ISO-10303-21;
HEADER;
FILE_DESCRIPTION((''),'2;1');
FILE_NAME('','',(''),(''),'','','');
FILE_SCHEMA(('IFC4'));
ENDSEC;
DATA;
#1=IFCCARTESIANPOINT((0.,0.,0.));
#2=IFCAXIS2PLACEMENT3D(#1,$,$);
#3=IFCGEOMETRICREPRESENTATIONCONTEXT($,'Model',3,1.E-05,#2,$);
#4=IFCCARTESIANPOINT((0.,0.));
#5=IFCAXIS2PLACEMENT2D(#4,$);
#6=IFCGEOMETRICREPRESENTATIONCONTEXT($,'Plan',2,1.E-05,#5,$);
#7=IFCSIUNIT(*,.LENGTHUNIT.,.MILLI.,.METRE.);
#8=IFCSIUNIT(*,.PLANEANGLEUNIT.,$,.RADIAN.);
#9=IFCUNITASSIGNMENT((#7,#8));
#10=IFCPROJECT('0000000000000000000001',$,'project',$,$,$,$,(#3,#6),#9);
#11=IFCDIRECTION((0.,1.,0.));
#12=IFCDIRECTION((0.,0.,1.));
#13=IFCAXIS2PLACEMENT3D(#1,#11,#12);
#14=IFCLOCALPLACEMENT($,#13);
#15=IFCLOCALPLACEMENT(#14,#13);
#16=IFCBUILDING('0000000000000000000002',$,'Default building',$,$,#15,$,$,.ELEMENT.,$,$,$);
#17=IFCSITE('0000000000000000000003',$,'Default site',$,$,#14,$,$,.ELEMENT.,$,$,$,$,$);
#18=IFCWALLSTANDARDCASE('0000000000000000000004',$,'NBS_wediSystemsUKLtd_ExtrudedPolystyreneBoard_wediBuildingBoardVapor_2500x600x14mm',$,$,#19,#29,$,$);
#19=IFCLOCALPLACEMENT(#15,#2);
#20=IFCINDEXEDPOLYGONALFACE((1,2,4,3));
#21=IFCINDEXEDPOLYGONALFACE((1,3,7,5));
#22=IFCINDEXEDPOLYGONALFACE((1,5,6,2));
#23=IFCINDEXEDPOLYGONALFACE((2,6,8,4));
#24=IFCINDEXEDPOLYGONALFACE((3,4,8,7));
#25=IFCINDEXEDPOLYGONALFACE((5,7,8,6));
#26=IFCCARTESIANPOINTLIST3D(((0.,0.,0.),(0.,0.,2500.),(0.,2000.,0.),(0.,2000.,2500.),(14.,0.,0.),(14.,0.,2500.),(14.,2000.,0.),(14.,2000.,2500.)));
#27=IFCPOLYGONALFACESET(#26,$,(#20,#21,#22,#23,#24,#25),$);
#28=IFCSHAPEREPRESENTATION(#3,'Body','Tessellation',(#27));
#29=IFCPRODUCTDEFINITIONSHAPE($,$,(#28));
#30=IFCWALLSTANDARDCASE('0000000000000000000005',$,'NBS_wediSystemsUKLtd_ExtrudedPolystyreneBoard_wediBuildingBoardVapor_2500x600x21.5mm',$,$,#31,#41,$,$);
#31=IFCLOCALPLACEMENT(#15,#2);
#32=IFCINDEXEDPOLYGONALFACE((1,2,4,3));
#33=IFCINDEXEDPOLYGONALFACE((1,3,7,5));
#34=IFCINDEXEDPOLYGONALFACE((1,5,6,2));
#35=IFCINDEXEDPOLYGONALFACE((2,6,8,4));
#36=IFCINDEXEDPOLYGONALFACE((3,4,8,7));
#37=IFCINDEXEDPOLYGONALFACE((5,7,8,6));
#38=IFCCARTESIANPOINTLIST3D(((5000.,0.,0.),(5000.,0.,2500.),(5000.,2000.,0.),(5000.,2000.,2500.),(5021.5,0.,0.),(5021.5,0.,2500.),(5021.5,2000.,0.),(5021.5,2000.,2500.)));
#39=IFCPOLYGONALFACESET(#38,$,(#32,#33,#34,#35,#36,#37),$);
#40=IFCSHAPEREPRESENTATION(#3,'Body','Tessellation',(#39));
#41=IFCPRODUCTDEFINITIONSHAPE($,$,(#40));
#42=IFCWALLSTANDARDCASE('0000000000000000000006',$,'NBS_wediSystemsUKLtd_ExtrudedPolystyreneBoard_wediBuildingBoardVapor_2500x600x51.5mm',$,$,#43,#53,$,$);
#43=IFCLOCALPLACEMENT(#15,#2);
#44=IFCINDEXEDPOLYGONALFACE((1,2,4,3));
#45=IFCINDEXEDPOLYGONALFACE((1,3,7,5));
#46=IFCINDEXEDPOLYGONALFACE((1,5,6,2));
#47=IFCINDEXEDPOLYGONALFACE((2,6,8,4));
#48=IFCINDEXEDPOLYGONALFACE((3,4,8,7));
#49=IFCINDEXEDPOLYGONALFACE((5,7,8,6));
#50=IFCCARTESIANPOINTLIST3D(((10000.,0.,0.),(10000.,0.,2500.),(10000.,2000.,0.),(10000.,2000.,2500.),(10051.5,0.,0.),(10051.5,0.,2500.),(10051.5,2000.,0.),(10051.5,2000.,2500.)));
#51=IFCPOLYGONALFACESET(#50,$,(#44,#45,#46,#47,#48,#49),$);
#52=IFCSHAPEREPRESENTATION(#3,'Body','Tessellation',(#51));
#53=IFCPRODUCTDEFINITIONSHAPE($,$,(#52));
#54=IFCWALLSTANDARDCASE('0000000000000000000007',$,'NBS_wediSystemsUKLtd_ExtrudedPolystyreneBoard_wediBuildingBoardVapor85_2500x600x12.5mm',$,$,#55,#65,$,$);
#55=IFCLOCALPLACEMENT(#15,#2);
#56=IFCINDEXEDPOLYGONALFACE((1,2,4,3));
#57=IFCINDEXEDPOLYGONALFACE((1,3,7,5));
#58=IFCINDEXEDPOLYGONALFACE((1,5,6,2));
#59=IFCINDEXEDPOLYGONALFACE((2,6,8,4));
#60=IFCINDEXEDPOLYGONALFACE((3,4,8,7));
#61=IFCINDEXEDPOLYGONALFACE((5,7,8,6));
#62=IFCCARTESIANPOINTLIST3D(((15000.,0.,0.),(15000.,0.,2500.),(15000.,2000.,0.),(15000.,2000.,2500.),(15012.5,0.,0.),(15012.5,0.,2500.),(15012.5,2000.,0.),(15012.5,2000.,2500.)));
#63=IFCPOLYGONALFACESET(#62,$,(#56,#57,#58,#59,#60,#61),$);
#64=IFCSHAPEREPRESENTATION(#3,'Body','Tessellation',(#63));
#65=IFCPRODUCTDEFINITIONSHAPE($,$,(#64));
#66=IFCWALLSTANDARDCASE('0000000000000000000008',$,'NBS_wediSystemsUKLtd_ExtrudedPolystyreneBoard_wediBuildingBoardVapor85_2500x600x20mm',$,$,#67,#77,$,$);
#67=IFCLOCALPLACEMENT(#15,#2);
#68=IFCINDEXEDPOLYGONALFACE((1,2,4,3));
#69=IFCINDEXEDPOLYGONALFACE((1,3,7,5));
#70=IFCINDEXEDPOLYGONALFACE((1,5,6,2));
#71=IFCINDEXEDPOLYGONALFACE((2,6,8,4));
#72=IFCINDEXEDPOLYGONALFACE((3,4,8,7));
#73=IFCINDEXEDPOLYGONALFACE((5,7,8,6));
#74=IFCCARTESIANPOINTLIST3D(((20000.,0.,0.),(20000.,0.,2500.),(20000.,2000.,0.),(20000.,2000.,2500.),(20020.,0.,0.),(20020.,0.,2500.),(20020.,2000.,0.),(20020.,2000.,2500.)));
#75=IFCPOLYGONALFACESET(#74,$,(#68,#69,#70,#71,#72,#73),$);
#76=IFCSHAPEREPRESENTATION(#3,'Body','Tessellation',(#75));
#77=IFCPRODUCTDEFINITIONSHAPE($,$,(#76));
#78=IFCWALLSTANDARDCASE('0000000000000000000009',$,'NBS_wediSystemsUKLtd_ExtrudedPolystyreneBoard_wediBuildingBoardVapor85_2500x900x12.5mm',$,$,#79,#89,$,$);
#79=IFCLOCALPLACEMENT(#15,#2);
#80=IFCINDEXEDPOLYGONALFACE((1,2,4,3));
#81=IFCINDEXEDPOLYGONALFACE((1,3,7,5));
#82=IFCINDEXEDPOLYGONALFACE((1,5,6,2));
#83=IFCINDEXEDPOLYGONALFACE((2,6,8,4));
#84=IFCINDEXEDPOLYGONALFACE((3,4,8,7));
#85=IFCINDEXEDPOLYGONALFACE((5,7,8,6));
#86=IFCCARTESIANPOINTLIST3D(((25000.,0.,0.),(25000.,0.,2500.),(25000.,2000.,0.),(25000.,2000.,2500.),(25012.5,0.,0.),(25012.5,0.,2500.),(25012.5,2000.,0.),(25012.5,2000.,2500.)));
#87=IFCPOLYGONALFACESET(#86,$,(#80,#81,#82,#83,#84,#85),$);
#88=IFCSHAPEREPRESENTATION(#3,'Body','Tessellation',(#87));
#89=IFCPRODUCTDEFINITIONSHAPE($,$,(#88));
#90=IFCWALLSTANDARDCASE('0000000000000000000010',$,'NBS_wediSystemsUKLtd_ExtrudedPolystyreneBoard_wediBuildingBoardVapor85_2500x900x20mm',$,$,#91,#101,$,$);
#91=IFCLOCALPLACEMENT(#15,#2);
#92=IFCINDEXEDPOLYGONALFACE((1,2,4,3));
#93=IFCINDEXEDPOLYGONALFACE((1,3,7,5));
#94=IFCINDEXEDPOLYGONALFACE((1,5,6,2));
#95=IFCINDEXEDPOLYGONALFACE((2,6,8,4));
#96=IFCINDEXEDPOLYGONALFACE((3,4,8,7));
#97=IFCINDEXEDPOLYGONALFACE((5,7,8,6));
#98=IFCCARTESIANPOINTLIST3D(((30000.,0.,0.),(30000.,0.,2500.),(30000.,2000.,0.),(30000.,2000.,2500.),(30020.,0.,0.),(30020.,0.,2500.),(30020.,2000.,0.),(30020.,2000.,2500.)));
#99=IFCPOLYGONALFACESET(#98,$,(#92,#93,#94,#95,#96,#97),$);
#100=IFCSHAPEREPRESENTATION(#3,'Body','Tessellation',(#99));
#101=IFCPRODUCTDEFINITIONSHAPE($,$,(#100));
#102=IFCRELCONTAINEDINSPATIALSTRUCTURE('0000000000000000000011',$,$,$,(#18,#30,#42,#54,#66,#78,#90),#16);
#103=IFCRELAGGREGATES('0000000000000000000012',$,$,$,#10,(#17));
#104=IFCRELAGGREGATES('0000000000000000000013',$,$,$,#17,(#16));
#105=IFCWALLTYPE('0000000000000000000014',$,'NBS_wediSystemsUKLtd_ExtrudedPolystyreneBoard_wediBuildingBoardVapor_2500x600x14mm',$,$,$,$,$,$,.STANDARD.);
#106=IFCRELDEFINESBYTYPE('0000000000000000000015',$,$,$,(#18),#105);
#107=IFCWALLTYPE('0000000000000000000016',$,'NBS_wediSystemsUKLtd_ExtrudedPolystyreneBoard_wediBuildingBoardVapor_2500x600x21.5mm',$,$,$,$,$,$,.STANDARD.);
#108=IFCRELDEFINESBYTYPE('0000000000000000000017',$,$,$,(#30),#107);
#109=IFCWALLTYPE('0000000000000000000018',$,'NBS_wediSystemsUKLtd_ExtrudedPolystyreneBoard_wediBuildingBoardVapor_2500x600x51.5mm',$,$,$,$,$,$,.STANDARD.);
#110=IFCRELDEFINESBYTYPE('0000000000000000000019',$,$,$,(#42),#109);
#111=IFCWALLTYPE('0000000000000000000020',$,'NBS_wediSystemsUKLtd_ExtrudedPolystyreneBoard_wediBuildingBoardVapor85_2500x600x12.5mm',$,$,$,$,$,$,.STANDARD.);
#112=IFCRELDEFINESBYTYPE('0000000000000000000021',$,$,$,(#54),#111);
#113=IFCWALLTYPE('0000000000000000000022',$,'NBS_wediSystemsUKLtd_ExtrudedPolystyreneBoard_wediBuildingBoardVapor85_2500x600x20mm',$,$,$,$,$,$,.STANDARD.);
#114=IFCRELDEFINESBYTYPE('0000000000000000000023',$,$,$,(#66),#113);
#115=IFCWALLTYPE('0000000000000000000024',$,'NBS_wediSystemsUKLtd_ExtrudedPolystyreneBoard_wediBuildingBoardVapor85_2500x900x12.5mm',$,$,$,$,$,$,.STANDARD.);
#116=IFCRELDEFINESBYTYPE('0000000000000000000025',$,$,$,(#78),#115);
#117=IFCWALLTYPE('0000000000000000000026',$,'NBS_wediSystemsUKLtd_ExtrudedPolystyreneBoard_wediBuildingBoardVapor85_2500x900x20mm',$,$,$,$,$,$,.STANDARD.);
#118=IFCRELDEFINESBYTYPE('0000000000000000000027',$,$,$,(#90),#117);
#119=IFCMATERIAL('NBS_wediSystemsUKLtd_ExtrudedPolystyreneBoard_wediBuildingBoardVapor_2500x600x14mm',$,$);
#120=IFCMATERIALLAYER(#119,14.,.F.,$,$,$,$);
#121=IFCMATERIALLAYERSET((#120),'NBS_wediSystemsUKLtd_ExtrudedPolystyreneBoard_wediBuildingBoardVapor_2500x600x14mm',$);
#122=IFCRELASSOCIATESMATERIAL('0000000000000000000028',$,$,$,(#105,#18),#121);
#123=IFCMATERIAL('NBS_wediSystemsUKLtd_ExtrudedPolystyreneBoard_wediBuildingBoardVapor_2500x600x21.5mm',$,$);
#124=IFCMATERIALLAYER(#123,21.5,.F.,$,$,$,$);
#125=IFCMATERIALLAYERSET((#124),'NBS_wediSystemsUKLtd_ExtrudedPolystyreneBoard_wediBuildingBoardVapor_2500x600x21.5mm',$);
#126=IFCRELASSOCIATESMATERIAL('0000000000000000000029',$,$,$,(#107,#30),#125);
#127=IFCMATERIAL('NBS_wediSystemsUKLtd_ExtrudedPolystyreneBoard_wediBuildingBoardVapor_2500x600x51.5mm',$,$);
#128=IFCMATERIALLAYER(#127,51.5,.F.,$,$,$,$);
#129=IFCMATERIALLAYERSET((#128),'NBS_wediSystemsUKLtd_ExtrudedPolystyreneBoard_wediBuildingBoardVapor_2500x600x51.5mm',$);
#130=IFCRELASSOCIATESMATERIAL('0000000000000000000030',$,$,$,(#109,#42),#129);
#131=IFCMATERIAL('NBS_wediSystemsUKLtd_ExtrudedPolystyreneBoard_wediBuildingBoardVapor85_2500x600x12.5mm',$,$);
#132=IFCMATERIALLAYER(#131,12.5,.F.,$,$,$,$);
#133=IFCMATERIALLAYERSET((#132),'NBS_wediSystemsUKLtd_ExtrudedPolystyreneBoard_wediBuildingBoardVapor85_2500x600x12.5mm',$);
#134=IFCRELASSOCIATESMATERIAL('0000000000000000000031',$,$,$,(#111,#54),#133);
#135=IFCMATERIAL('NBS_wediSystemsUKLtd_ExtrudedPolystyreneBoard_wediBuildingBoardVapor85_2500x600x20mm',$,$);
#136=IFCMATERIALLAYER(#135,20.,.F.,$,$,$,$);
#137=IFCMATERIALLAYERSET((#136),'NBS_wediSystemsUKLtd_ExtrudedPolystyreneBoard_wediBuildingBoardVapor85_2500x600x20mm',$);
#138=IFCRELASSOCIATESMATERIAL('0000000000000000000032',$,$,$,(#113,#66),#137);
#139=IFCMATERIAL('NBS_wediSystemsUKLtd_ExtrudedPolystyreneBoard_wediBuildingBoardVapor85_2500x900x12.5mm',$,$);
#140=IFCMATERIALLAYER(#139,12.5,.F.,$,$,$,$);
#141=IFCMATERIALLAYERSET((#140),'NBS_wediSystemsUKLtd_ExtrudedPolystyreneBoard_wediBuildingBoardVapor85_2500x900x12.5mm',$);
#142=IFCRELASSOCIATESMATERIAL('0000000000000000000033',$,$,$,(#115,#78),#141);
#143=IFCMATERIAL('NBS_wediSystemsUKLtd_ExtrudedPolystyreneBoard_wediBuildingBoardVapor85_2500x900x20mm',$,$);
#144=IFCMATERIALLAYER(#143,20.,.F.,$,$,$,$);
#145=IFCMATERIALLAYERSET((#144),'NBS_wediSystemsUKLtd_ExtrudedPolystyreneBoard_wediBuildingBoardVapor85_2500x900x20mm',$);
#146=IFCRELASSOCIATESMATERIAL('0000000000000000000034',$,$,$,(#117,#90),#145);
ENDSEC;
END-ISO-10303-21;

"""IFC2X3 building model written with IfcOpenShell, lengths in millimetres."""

from ifc_helpers import new_model, si_unit, frame, frame_2d, origin, origin_with_axes, origin_2d, place, context, project, spatial, rectangle, extrude, material, layer, layer_set, layer_usage, type_object, element, save


model = new_model("IFC2X3")

# Units and contexts
model_context = context("Model", 3, precision=1e-05, world=origin())
plan_context = context("Plan", 2, precision=1e-05, world=origin_2d())
ifc_project = project(units=[si_unit("LENGTHUNIT", "METRE", prefix="MILLI"), si_unit("PLANEANGLEUNIT", "RADIAN")], contexts=[model_context, plan_context])

# Site, building
site_placement = place(None, frame((0.0, 0.0, 0.0), z_axis=(0.0, 1.0, 0.0), x_axis=(0.0, 0.0, 1.0)))
site = spatial("IfcSite", under=ifc_project, at=site_placement, Name="Default site", CompositionType="ELEMENT")
building_placement = place(site_placement, frame((0.0, 0.0, 0.0), z_axis=(0.0, 1.0, 0.0), x_axis=(0.0, 0.0, 1.0)))
building = spatial("IfcBuilding", under=site, at=building_placement, Name="Default building", CompositionType="ELEMENT")

# Walls
ifc_material_1 = material(Name="NBS_wediSystemsUKLtd_ExtrudedPolystyreneBoard_wediBuildingBoardVapor_2500x600x14mm")
ifc_layer_1 = layer(ifc_material_1, 14.0, ventilated=False)
ifc_layer_set_1 = layer_set([ifc_layer_1], Name="NBS_wediSystemsUKLtd_ExtrudedPolystyreneBoard_wediBuildingBoardVapor_2500x600x14mm")
ifc_layer_usage_1 = layer_usage(ifc_layer_set_1, "AXIS2", "POSITIVE", 0.0)
wall_type_1 = type_object("IfcWallType", Name="NBS_wediSystemsUKLtd_ExtrudedPolystyreneBoard_wediBuildingBoardVapor_2500x600x14mm", PredefinedType="STANDARD", material=ifc_layer_set_1)
wall_1_placement = place(None, origin())
element("IfcWallStandardCase", 1, at=wall_1_placement, inside=building, type_object=wall_type_1, material=ifc_layer_usage_1, Name="NBS_wediSystemsUKLtd_ExtrudedPolystyreneBoard_wediBuildingBoardVapor_2500x600x14mm", context=model_context, shape_type="SweptSolid", body=[
    extrude(rectangle(XDim=2500.0, YDim=14.0, at=frame_2d((1250.0, 7.0))), origin_with_axes(), (0.0, 0.0, 1.0), 2000.0),
])
ifc_material_2 = material(Name="NBS_wediSystemsUKLtd_ExtrudedPolystyreneBoard_wediBuildingBoardVapor_2500x600x21.5mm")
ifc_layer_2 = layer(ifc_material_2, 21.5, ventilated=False)
ifc_layer_set_2 = layer_set([ifc_layer_2], Name="NBS_wediSystemsUKLtd_ExtrudedPolystyreneBoard_wediBuildingBoardVapor_2500x600x21.5mm")
ifc_layer_usage_2 = layer_usage(ifc_layer_set_2, "AXIS2", "POSITIVE", 0.0)
wall_type_2 = type_object("IfcWallType", Name="NBS_wediSystemsUKLtd_ExtrudedPolystyreneBoard_wediBuildingBoardVapor_2500x600x21.5mm", PredefinedType="STANDARD", material=ifc_layer_set_2)
wall_2_placement = place(None, frame((0.0, 5000.0, 0.0)))
element("IfcWallStandardCase", 2, at=wall_2_placement, inside=building, type_object=wall_type_2, material=ifc_layer_usage_2, Name="NBS_wediSystemsUKLtd_ExtrudedPolystyreneBoard_wediBuildingBoardVapor_2500x600x21.5mm", context=model_context, shape_type="SweptSolid", body=[
    extrude(rectangle(XDim=2500.0, YDim=21.5, at=frame_2d((1250.0, 10.8))), origin_with_axes(), (0.0, 0.0, 1.0), 2000.0),
])
ifc_material_3 = material(Name="NBS_wediSystemsUKLtd_ExtrudedPolystyreneBoard_wediBuildingBoardVapor_2500x600x51.5mm")
ifc_layer_3 = layer(ifc_material_3, 51.5, ventilated=False)
ifc_layer_set_3 = layer_set([ifc_layer_3], Name="NBS_wediSystemsUKLtd_ExtrudedPolystyreneBoard_wediBuildingBoardVapor_2500x600x51.5mm")
ifc_layer_usage_3 = layer_usage(ifc_layer_set_3, "AXIS2", "POSITIVE", 0.0)
wall_type_3 = type_object("IfcWallType", Name="NBS_wediSystemsUKLtd_ExtrudedPolystyreneBoard_wediBuildingBoardVapor_2500x600x51.5mm", PredefinedType="STANDARD", material=ifc_layer_set_3)
wall_3_placement = place(None, frame((0.0, 10000.0, 0.0)))
element("IfcWallStandardCase", 3, at=wall_3_placement, inside=building, type_object=wall_type_3, material=ifc_layer_usage_3, Name="NBS_wediSystemsUKLtd_ExtrudedPolystyreneBoard_wediBuildingBoardVapor_2500x600x51.5mm", context=model_context, shape_type="SweptSolid", body=[
    extrude(rectangle(XDim=2500.0, YDim=51.5, at=frame_2d((1250.0, 25.8))), origin_with_axes(), (0.0, 0.0, 1.0), 2000.0),
])
ifc_material_4 = material(Name="NBS_wediSystemsUKLtd_ExtrudedPolystyreneBoard_wediBuildingBoardVapor85_2500x600x12.5mm")
ifc_layer_4 = layer(ifc_material_4, 12.5, ventilated=False)
ifc_layer_set_4 = layer_set([ifc_layer_4], Name="NBS_wediSystemsUKLtd_ExtrudedPolystyreneBoard_wediBuildingBoardVapor85_2500x600x12.5mm")
ifc_layer_usage_4 = layer_usage(ifc_layer_set_4, "AXIS2", "POSITIVE", 0.0)
wall_type_4 = type_object("IfcWallType", Name="NBS_wediSystemsUKLtd_ExtrudedPolystyreneBoard_wediBuildingBoardVapor85_2500x600x12.5mm", PredefinedType="STANDARD", material=ifc_layer_set_4)
wall_4_placement = place(None, frame((0.0, 15000.0, 0.0)))
element("IfcWallStandardCase", 4, at=wall_4_placement, inside=building, type_object=wall_type_4, material=ifc_layer_usage_4, Name="NBS_wediSystemsUKLtd_ExtrudedPolystyreneBoard_wediBuildingBoardVapor85_2500x600x12.5mm", context=model_context, shape_type="SweptSolid", body=[
    extrude(rectangle(XDim=2500.0, YDim=12.5, at=frame_2d((1250.0, 6.2))), origin_with_axes(), (0.0, 0.0, 1.0), 2000.0),
])
ifc_material_5 = material(Name="NBS_wediSystemsUKLtd_ExtrudedPolystyreneBoard_wediBuildingBoardVapor85_2500x600x20mm")
ifc_layer_5 = layer(ifc_material_5, 20.0, ventilated=False)
ifc_layer_set_5 = layer_set([ifc_layer_5], Name="NBS_wediSystemsUKLtd_ExtrudedPolystyreneBoard_wediBuildingBoardVapor85_2500x600x20mm")
ifc_layer_usage_5 = layer_usage(ifc_layer_set_5, "AXIS2", "POSITIVE", 0.0)
wall_type_5 = type_object("IfcWallType", Name="NBS_wediSystemsUKLtd_ExtrudedPolystyreneBoard_wediBuildingBoardVapor85_2500x600x20mm", PredefinedType="STANDARD", material=ifc_layer_set_5)
wall_5_placement = place(None, frame((0.0, 20000.0, 0.0)))
element("IfcWallStandardCase", 5, at=wall_5_placement, inside=building, type_object=wall_type_5, material=ifc_layer_usage_5, Name="NBS_wediSystemsUKLtd_ExtrudedPolystyreneBoard_wediBuildingBoardVapor85_2500x600x20mm", context=model_context, shape_type="SweptSolid", body=[
    extrude(rectangle(XDim=2500.0, YDim=20.0, at=frame_2d((1250.0, 10.0))), origin_with_axes(), (0.0, 0.0, 1.0), 2000.0),
])
ifc_material_6 = material(Name="NBS_wediSystemsUKLtd_ExtrudedPolystyreneBoard_wediBuildingBoardVapor85_2500x900x12.5mm")
ifc_layer_6 = layer(ifc_material_6, 12.5, ventilated=False)
ifc_layer_set_6 = layer_set([ifc_layer_6], Name="NBS_wediSystemsUKLtd_ExtrudedPolystyreneBoard_wediBuildingBoardVapor85_2500x900x12.5mm")
ifc_layer_usage_6 = layer_usage(ifc_layer_set_6, "AXIS2", "POSITIVE", 0.0)
wall_type_6 = type_object("IfcWallType", Name="NBS_wediSystemsUKLtd_ExtrudedPolystyreneBoard_wediBuildingBoardVapor85_2500x900x12.5mm", PredefinedType="STANDARD", material=ifc_layer_set_6)
wall_6_placement = place(None, frame((0.0, 25000.0, 0.0)))
element("IfcWallStandardCase", 6, at=wall_6_placement, inside=building, type_object=wall_type_6, material=ifc_layer_usage_6, Name="NBS_wediSystemsUKLtd_ExtrudedPolystyreneBoard_wediBuildingBoardVapor85_2500x900x12.5mm", context=model_context, shape_type="SweptSolid", body=[
    extrude(rectangle(XDim=2500.0, YDim=12.5, at=frame_2d((1250.0, 6.2))), origin_with_axes(), (0.0, 0.0, 1.0), 2000.0),
])
ifc_material_7 = material(Name="NBS_wediSystemsUKLtd_ExtrudedPolystyreneBoard_wediBuildingBoardVapor85_2500x900x20mm")
ifc_layer_7 = layer(ifc_material_7, 20.0, ventilated=False)
ifc_layer_set_7 = layer_set([ifc_layer_7], Name="NBS_wediSystemsUKLtd_ExtrudedPolystyreneBoard_wediBuildingBoardVapor85_2500x900x20mm")
ifc_layer_usage_7 = layer_usage(ifc_layer_set_7, "AXIS2", "POSITIVE", 0.0)
wall_type_7 = type_object("IfcWallType", Name="NBS_wediSystemsUKLtd_ExtrudedPolystyreneBoard_wediBuildingBoardVapor85_2500x900x20mm", PredefinedType="STANDARD", material=ifc_layer_set_7)
wall_7_placement = place(None, frame((0.0, 30000.0, 0.0)))
element("IfcWallStandardCase", 7, at=wall_7_placement, inside=building, type_object=wall_type_7, material=ifc_layer_usage_7, Name="NBS_wediSystemsUKLtd_ExtrudedPolystyreneBoard_wediBuildingBoardVapor85_2500x900x20mm", context=model_context, shape_type="SweptSolid", body=[
    extrude(rectangle(XDim=2500.0, YDim=20.0, at=frame_2d((1250.0, 10.0))), origin_with_axes(), (0.0, 0.0, 1.0), 2000.0),
])

save(model, "model.ifc")
